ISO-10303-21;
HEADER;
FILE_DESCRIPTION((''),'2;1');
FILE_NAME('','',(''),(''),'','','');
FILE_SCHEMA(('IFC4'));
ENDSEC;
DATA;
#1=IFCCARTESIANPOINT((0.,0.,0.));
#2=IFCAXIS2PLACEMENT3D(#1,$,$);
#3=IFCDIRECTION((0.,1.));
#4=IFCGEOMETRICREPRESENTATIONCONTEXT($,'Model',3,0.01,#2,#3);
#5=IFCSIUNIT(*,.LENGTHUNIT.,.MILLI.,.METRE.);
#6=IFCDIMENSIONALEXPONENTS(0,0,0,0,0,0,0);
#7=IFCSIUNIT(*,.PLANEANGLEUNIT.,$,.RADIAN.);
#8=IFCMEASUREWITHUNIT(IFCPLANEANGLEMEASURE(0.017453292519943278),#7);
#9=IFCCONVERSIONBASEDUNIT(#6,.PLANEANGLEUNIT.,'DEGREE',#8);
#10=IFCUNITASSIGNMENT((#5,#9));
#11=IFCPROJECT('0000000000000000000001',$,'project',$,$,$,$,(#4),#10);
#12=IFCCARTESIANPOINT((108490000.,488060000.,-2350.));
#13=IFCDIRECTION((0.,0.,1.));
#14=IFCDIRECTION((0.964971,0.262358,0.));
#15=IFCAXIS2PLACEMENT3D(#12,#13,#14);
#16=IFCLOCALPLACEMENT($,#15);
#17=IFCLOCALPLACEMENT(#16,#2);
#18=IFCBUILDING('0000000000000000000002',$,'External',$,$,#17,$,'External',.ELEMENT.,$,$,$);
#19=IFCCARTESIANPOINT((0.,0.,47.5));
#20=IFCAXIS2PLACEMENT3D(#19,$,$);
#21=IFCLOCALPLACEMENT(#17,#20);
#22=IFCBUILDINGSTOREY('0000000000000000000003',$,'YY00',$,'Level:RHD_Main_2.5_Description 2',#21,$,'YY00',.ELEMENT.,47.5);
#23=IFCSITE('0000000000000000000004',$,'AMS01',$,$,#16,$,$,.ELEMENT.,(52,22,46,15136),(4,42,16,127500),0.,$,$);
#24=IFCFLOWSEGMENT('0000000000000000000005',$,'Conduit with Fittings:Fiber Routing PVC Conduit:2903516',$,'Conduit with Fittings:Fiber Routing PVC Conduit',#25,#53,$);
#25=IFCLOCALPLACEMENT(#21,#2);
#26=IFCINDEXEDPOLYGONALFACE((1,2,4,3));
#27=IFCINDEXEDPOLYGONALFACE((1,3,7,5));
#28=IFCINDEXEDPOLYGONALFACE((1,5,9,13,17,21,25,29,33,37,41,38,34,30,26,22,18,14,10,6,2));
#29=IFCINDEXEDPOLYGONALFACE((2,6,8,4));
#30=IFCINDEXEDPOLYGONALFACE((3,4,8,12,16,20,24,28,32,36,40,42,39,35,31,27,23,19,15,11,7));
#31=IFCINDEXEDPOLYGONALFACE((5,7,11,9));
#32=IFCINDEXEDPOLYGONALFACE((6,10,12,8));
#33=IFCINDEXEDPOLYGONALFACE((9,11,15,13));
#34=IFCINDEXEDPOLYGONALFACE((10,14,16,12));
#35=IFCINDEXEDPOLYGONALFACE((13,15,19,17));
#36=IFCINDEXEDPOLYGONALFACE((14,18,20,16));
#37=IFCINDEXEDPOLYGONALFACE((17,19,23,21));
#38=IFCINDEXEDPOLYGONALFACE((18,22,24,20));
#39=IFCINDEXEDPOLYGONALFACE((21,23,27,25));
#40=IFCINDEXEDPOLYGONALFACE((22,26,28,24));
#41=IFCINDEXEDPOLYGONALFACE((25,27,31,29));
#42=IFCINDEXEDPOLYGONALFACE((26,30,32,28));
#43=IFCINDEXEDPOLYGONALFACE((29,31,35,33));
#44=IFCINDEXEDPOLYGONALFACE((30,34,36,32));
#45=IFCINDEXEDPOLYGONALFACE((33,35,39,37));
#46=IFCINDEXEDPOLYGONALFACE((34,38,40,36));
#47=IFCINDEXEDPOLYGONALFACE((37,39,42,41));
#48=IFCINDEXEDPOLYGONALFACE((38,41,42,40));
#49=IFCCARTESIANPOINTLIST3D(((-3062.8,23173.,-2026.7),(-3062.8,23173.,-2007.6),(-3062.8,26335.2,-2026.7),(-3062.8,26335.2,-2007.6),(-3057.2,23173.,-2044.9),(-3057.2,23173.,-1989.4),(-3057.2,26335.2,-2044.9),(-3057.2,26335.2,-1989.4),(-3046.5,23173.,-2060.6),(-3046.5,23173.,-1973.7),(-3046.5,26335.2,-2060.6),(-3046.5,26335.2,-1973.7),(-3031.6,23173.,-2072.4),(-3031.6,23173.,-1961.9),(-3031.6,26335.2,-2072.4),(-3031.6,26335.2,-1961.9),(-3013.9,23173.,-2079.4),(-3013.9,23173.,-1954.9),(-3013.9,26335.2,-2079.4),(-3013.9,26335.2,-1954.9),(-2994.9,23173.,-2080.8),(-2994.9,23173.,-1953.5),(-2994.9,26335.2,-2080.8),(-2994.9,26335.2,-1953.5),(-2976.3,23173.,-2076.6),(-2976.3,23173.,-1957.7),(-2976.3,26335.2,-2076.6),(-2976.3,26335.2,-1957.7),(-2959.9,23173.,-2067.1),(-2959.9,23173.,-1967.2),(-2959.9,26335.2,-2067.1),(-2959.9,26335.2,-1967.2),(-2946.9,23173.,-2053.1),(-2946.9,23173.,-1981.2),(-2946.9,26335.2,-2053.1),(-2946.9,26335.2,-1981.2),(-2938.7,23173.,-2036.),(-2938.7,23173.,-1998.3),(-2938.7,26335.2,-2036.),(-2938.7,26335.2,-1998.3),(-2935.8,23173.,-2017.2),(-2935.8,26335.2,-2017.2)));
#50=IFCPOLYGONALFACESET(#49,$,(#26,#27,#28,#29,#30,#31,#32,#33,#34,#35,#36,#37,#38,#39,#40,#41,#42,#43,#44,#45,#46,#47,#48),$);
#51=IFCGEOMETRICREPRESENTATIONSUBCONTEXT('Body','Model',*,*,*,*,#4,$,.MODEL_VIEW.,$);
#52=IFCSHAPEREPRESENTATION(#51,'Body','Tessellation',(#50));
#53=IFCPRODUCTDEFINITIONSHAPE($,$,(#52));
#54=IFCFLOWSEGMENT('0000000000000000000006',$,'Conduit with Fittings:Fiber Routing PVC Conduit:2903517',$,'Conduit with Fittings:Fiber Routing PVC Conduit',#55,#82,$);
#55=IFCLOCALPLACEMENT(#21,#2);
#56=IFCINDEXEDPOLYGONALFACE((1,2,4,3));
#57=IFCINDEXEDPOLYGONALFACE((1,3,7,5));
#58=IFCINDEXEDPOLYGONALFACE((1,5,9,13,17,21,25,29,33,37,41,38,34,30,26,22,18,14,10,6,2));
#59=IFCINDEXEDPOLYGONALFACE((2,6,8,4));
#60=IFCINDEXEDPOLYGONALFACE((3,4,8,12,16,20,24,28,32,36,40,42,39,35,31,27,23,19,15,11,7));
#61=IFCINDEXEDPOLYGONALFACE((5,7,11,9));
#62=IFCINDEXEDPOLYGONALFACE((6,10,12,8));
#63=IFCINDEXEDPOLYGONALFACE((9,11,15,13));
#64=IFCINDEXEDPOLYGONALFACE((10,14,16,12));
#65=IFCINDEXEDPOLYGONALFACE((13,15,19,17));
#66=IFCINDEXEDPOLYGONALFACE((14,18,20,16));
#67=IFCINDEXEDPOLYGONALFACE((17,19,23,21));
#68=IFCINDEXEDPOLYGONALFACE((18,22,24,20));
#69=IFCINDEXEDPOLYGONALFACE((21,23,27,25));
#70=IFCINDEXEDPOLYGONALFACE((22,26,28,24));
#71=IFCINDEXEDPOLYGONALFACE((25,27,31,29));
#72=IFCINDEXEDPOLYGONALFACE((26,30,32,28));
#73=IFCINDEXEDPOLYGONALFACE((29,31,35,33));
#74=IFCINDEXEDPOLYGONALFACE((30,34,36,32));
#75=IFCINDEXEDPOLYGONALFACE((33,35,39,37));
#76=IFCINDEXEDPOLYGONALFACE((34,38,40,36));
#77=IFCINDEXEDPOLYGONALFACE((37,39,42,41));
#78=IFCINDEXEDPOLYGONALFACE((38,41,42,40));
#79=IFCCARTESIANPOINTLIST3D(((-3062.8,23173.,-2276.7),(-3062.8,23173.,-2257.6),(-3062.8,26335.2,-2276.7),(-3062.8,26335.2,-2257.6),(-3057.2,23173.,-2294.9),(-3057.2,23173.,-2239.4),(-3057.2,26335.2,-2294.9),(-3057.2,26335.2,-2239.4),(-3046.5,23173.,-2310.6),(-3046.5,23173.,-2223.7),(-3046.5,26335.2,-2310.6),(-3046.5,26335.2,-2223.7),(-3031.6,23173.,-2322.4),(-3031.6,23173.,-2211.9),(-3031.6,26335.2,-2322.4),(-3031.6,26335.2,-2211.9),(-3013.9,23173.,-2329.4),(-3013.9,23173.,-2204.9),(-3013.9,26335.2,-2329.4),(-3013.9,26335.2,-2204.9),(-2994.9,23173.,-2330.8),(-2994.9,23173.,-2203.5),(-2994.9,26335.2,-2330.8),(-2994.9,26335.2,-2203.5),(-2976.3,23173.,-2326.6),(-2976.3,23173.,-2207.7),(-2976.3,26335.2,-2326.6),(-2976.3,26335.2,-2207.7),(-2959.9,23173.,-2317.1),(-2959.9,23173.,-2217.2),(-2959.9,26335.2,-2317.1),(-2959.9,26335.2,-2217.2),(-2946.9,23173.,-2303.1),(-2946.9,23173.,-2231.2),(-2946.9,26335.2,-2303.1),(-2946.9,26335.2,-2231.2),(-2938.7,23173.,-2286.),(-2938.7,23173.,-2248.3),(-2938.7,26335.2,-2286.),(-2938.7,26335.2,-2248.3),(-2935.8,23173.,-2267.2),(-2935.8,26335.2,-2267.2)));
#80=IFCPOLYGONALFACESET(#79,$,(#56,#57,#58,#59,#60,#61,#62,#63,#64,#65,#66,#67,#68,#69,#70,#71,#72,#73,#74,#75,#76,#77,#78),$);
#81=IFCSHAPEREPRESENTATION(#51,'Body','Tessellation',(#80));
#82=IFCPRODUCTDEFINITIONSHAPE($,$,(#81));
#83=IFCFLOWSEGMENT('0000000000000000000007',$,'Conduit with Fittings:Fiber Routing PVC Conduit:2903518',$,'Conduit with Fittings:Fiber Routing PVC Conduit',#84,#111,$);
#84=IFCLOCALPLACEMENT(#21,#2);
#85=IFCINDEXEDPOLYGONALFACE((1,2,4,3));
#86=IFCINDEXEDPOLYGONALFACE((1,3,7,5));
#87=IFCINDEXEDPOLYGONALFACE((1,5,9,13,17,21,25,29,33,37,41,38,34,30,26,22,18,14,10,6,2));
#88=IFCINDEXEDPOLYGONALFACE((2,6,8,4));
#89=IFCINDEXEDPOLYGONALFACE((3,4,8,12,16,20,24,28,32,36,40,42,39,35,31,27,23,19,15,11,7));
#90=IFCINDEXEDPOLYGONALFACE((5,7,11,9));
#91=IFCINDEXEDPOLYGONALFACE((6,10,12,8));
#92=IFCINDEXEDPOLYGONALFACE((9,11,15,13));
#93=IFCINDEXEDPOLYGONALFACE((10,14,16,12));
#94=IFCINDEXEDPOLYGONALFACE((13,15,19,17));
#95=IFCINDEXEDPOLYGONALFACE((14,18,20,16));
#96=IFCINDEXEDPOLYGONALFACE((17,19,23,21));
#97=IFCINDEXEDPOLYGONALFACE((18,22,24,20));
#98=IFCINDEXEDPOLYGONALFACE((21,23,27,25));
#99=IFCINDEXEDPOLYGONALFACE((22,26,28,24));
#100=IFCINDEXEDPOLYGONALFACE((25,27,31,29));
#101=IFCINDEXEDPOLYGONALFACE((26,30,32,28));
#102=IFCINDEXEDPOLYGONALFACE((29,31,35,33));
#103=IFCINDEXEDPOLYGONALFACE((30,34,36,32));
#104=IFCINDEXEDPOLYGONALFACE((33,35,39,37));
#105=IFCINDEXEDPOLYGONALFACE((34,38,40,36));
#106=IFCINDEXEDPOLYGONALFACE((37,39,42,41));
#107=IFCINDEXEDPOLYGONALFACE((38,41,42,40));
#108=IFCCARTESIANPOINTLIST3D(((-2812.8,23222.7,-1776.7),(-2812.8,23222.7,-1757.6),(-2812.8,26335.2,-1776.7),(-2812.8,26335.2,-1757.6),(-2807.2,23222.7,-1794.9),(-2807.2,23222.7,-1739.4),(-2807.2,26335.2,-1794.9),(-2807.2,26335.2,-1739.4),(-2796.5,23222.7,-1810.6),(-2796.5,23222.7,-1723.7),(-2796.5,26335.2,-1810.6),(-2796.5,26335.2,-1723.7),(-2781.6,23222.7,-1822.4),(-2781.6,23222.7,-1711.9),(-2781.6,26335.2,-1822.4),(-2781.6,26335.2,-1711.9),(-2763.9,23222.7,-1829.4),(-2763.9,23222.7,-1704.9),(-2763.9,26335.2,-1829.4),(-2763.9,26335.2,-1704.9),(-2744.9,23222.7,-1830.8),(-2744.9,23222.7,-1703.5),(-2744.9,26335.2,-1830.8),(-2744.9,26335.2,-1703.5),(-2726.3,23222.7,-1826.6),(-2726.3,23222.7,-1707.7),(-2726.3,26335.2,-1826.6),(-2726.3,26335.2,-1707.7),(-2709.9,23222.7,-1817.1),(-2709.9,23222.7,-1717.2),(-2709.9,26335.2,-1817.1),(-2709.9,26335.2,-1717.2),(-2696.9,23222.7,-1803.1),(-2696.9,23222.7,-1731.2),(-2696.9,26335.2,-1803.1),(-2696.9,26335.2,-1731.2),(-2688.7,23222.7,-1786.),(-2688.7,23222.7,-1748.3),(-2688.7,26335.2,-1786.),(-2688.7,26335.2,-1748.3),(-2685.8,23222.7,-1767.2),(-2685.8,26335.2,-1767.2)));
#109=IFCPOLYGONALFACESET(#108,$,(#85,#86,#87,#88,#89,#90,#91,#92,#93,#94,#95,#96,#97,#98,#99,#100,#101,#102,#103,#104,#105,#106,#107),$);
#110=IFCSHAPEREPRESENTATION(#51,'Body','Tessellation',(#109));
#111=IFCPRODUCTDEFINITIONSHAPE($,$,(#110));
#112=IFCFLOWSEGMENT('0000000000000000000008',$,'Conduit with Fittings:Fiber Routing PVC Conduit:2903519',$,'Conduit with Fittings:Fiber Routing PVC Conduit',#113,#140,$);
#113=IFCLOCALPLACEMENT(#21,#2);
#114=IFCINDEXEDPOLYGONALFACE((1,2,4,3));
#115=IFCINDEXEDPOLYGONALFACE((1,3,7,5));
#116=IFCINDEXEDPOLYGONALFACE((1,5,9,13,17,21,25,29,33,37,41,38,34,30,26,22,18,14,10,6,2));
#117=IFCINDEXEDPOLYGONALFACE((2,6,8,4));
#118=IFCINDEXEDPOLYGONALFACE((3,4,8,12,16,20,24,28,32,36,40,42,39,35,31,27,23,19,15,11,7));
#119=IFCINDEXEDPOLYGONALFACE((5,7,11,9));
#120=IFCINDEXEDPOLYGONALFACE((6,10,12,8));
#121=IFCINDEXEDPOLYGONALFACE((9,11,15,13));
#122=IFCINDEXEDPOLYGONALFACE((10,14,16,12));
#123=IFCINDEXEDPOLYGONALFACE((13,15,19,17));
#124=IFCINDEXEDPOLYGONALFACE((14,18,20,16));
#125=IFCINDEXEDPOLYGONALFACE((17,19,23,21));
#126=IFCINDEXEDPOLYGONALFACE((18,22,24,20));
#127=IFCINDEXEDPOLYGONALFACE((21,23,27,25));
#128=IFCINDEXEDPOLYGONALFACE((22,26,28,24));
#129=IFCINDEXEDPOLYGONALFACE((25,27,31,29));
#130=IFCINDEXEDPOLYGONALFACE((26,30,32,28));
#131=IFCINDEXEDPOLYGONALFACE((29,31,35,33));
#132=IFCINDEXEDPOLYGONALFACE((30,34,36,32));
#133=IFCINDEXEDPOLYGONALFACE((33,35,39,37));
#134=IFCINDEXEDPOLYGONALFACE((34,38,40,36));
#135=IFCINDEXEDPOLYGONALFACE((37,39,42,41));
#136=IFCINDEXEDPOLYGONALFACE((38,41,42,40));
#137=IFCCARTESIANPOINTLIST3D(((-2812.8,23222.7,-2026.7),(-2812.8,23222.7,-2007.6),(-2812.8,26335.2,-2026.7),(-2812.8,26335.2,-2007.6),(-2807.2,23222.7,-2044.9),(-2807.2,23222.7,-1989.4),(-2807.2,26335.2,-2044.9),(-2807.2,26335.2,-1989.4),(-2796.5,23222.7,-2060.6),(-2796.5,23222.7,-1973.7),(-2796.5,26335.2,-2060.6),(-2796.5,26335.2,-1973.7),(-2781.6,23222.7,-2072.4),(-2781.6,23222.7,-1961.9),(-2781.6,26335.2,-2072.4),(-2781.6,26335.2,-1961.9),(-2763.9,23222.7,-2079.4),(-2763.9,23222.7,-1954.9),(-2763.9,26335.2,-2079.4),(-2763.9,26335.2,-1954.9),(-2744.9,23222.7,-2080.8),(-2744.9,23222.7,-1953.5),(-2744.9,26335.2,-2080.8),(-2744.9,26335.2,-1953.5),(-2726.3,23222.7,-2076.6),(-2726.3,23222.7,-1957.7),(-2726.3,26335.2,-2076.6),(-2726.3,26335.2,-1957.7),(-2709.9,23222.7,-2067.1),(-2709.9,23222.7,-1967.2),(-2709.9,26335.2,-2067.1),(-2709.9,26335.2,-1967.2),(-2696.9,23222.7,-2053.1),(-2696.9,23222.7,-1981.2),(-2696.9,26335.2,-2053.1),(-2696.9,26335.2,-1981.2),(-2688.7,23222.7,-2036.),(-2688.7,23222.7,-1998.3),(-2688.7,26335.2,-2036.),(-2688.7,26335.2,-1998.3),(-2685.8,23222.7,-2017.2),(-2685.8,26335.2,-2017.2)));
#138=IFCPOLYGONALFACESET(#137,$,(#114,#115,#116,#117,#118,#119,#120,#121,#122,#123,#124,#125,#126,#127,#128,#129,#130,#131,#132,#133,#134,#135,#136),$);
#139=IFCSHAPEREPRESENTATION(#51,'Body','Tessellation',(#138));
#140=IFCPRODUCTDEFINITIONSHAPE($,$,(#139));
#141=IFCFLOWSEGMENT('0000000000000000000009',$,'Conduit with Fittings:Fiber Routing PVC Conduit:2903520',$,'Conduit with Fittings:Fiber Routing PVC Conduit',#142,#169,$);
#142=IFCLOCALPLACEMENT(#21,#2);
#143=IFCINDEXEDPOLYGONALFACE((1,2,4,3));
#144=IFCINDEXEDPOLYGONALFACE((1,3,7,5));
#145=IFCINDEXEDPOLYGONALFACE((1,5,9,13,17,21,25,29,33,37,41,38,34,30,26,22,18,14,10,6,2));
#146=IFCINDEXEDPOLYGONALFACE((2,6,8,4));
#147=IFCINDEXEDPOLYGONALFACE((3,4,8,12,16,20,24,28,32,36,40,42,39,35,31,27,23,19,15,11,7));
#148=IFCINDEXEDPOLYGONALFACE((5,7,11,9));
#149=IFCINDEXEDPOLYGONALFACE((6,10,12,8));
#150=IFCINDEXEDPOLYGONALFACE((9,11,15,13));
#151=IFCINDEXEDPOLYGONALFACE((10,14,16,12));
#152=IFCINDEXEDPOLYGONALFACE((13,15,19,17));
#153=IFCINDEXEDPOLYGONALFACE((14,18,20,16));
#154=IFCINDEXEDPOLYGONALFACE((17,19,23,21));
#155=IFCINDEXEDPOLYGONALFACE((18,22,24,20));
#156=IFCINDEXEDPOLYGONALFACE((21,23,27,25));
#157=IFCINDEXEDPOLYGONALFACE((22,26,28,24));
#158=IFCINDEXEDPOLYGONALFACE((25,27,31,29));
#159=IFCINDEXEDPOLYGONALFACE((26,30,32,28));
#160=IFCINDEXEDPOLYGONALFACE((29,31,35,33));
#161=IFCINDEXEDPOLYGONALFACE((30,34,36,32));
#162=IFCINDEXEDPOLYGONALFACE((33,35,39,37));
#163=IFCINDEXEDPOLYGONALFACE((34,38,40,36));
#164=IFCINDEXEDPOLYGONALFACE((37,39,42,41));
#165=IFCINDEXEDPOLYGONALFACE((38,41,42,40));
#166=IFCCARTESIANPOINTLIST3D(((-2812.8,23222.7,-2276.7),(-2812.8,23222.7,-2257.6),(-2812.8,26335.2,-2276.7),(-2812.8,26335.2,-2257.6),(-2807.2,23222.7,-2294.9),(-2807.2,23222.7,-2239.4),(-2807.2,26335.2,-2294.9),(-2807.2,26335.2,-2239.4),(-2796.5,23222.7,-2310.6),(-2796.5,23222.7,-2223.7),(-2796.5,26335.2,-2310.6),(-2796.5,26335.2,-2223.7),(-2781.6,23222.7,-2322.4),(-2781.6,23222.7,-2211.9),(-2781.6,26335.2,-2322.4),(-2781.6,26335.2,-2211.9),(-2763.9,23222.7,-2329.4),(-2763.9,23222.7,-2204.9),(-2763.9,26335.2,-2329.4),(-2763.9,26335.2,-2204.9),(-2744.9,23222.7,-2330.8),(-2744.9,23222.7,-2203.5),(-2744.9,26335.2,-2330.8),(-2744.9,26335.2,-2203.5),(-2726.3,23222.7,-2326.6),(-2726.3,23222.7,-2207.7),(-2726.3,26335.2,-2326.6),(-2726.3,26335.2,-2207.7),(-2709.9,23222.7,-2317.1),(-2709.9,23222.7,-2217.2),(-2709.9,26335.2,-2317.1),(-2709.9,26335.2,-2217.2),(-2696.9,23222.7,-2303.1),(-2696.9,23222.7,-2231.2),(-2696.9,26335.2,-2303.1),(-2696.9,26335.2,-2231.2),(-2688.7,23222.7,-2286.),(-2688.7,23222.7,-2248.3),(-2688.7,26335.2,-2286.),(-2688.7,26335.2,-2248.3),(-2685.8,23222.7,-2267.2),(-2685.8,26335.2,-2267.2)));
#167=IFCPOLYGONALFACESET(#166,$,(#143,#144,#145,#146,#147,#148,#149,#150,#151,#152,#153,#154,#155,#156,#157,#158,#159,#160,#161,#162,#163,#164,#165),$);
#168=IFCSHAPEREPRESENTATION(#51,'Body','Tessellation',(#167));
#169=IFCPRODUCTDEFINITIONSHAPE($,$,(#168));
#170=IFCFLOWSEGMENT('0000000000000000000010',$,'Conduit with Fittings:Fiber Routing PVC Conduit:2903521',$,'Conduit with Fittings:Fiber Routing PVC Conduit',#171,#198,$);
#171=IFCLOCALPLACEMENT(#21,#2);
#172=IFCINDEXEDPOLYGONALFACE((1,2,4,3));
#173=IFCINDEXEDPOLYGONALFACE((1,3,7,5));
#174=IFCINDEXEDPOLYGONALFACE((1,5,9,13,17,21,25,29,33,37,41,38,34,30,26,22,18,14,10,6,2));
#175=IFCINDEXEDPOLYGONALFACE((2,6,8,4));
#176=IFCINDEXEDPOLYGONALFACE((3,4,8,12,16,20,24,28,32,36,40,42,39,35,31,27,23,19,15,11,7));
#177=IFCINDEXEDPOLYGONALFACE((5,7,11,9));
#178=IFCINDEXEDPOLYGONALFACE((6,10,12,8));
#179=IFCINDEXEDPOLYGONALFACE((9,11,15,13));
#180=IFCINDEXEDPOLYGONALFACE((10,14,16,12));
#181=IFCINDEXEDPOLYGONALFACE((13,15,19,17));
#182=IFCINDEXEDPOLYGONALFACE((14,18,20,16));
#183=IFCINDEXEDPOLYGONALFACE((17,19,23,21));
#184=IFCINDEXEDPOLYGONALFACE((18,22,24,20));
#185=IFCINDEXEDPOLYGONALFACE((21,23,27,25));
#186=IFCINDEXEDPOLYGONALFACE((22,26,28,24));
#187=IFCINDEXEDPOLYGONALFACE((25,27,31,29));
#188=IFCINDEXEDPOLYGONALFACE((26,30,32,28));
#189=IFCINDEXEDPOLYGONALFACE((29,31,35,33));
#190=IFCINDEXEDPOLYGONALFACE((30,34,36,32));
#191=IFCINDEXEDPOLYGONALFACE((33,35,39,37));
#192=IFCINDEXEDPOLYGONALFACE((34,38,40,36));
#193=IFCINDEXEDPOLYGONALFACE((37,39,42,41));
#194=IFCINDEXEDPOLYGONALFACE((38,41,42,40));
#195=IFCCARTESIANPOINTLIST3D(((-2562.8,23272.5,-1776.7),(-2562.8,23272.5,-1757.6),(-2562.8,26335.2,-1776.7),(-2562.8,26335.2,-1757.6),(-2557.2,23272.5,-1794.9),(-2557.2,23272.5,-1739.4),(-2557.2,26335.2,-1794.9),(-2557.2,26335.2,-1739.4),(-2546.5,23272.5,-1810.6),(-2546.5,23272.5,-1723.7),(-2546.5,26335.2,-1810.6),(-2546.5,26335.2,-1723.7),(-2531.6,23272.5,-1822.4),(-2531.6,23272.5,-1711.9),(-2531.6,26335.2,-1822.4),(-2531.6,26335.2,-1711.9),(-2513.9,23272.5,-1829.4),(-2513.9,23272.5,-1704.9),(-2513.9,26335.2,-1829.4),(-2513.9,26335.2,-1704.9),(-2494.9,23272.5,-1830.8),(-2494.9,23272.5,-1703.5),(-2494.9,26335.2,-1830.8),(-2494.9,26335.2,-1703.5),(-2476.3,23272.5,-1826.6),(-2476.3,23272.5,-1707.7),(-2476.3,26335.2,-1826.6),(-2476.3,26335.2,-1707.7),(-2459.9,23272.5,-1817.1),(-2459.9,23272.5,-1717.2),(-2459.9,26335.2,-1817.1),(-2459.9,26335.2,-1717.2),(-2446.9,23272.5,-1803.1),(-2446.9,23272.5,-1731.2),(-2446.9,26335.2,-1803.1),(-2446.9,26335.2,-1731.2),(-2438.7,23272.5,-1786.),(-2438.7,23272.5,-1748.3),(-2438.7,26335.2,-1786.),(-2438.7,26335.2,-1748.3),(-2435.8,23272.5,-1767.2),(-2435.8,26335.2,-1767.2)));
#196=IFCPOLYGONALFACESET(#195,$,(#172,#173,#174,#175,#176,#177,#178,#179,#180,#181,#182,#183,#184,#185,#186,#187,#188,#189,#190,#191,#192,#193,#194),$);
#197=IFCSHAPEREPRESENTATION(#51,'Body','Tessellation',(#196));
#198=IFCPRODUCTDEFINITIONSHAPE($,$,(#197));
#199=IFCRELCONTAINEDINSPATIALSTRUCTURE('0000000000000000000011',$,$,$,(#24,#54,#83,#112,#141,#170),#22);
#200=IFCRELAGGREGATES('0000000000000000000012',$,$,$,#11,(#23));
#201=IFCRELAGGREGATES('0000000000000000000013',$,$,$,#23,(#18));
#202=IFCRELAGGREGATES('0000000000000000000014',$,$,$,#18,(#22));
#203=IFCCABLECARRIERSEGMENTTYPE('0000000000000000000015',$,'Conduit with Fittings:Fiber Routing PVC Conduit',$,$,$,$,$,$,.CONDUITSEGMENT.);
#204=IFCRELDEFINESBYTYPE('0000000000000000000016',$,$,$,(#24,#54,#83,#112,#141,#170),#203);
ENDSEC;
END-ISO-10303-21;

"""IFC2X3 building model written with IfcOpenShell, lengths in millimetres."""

from ifc_helpers import new_model, entity, si_unit, converted_unit, direction, frame, frame_2d, origin, origin_2d_with_axis, place, context, subcontext, project, spatial, circle, extrude, type_object, element, save


model = new_model("IFC2X3")

# Units and contexts
model_context = context("Model", 3, precision=0.01, world=origin(), true_north=direction((0.0, 1.0)))
body_context = subcontext(model_context, "Body", "Model", "MODEL_VIEW")
ifc_project = project(units=[si_unit("LENGTHUNIT", "METRE", prefix="MILLI"), converted_unit("PLANEANGLEUNIT", "DEGREE", entity("IfcPlaneAngleMeasure", 0.017453292519943278), si_unit("PLANEANGLEUNIT", "RADIAN"), dimensions=[0, 0, 0, 0, 0, 0, 0])], contexts=[model_context])

# Site, building, storey
site_placement = place(None, frame((108490000.0, 488060000.0, -2350.0), z_axis=(0.0, 0.0, 1.0), x_axis=(0.964971, 0.262358, 0.0)))
site = spatial("IfcSite", under=ifc_project, at=site_placement, Name="AMS01", CompositionType="ELEMENT", RefLatitude=(52, 22, 46, 15136), RefLongitude=(4, 42, 16, 127500), RefElevation=0.0)
building_placement = place(site_placement, origin())
building = spatial("IfcBuilding", under=site, at=building_placement, Name="External", LongName="External", CompositionType="ELEMENT")
storey_placement = place(building_placement, frame((0.0, 0.0, 47.5)))
storey = spatial("IfcBuildingStorey", under=building, at=storey_placement, Name="YY00", ObjectType="Level:RHD_Main_2.5_Description 2", LongName="YY00", CompositionType="ELEMENT", Elevation=47.5)

# Flow segments
cable_carrier_segment_type = type_object("IfcCableCarrierSegmentType", Name="Conduit with Fittings:Fiber Routing PVC Conduit", PredefinedType="CONDUITSEGMENT")
flow_segment_1_placement = place(storey_placement, origin())
element("IfcFlowSegment", 1, at=flow_segment_1_placement, inside=storey, type_object=cable_carrier_segment_type, Name="Conduit with Fittings:Fiber Routing PVC Conduit:2903516", ObjectType="Conduit with Fittings:Fiber Routing PVC Conduit", context=body_context, shape_type="SweptSolid", body=[
    extrude(circle(Radius=63.9, at=origin_2d_with_axis()), frame((-2999.7, 23173.0, -2017.2), z_axis=(0.0, 1.0, 0.0), x_axis=(1.0, 0.0, 0.0)), (0.0, 0.0, 1.0), 3162.2),
])
flow_segment_2_placement = place(storey_placement, origin())
element("IfcFlowSegment", 2, at=flow_segment_2_placement, inside=storey, type_object=cable_carrier_segment_type, Name="Conduit with Fittings:Fiber Routing PVC Conduit:2903517", ObjectType="Conduit with Fittings:Fiber Routing PVC Conduit", context=body_context, shape_type="SweptSolid", body=[
    extrude(circle(Radius=63.9, at=origin_2d_with_axis()), frame((-2999.7, 23173.0, -2267.2), z_axis=(0.0, 1.0, 0.0), x_axis=(1.0, 0.0, 0.0)), (0.0, 0.0, 1.0), 3162.2),
])
flow_segment_3_placement = place(storey_placement, origin())
element("IfcFlowSegment", 3, at=flow_segment_3_placement, inside=storey, type_object=cable_carrier_segment_type, Name="Conduit with Fittings:Fiber Routing PVC Conduit:2903518", ObjectType="Conduit with Fittings:Fiber Routing PVC Conduit", context=body_context, shape_type="SweptSolid", body=[
    extrude(circle(Radius=63.9, at=frame_2d((0.0, 0.0), x_axis=(1.0, 0.0))), frame((-2749.7, 23222.7, -1767.2), z_axis=(0.0, 1.0, 0.0), x_axis=(1.0, 0.0, 0.0)), (0.0, 0.0, 1.0), 3112.5),
])
flow_segment_4_placement = place(storey_placement, origin())
element("IfcFlowSegment", 4, at=flow_segment_4_placement, inside=storey, type_object=cable_carrier_segment_type, Name="Conduit with Fittings:Fiber Routing PVC Conduit:2903519", ObjectType="Conduit with Fittings:Fiber Routing PVC Conduit", context=body_context, shape_type="SweptSolid", body=[
    extrude(circle(Radius=63.9, at=frame_2d((0.0, 0.0), x_axis=(1.0, 0.0))), frame((-2749.7, 23222.7, -2017.2), z_axis=(0.0, 1.0, 0.0), x_axis=(1.0, 0.0, 0.0)), (0.0, 0.0, 1.0), 3112.5),
])
flow_segment_5_placement = place(storey_placement, origin())
element("IfcFlowSegment", 5, at=flow_segment_5_placement, inside=storey, type_object=cable_carrier_segment_type, Name="Conduit with Fittings:Fiber Routing PVC Conduit:2903520", ObjectType="Conduit with Fittings:Fiber Routing PVC Conduit", context=body_context, shape_type="SweptSolid", body=[
    extrude(circle(Radius=63.9, at=frame_2d((0.0, 0.0), x_axis=(1.0, 0.0))), frame((-2749.7, 23222.7, -2267.2), z_axis=(0.0, 1.0, 0.0), x_axis=(1.0, 0.0, 0.0)), (0.0, 0.0, 1.0), 3112.5),
])
flow_segment_6_placement = place(storey_placement, origin())
element("IfcFlowSegment", 6, at=flow_segment_6_placement, inside=storey, type_object=cable_carrier_segment_type, Name="Conduit with Fittings:Fiber Routing PVC Conduit:2903521", ObjectType="Conduit with Fittings:Fiber Routing PVC Conduit", context=body_context, shape_type="SweptSolid", body=[
    extrude(circle(Radius=63.9, at=frame_2d((0.0, 0.0), x_axis=(1.0, 0.0))), frame((-2499.7, 23272.5, -1767.2), z_axis=(0.0, 1.0, 0.0), x_axis=(1.0, 0.0, 0.0)), (0.0, 0.0, 1.0), 3062.7),
])

save(model, "model.ifc")
